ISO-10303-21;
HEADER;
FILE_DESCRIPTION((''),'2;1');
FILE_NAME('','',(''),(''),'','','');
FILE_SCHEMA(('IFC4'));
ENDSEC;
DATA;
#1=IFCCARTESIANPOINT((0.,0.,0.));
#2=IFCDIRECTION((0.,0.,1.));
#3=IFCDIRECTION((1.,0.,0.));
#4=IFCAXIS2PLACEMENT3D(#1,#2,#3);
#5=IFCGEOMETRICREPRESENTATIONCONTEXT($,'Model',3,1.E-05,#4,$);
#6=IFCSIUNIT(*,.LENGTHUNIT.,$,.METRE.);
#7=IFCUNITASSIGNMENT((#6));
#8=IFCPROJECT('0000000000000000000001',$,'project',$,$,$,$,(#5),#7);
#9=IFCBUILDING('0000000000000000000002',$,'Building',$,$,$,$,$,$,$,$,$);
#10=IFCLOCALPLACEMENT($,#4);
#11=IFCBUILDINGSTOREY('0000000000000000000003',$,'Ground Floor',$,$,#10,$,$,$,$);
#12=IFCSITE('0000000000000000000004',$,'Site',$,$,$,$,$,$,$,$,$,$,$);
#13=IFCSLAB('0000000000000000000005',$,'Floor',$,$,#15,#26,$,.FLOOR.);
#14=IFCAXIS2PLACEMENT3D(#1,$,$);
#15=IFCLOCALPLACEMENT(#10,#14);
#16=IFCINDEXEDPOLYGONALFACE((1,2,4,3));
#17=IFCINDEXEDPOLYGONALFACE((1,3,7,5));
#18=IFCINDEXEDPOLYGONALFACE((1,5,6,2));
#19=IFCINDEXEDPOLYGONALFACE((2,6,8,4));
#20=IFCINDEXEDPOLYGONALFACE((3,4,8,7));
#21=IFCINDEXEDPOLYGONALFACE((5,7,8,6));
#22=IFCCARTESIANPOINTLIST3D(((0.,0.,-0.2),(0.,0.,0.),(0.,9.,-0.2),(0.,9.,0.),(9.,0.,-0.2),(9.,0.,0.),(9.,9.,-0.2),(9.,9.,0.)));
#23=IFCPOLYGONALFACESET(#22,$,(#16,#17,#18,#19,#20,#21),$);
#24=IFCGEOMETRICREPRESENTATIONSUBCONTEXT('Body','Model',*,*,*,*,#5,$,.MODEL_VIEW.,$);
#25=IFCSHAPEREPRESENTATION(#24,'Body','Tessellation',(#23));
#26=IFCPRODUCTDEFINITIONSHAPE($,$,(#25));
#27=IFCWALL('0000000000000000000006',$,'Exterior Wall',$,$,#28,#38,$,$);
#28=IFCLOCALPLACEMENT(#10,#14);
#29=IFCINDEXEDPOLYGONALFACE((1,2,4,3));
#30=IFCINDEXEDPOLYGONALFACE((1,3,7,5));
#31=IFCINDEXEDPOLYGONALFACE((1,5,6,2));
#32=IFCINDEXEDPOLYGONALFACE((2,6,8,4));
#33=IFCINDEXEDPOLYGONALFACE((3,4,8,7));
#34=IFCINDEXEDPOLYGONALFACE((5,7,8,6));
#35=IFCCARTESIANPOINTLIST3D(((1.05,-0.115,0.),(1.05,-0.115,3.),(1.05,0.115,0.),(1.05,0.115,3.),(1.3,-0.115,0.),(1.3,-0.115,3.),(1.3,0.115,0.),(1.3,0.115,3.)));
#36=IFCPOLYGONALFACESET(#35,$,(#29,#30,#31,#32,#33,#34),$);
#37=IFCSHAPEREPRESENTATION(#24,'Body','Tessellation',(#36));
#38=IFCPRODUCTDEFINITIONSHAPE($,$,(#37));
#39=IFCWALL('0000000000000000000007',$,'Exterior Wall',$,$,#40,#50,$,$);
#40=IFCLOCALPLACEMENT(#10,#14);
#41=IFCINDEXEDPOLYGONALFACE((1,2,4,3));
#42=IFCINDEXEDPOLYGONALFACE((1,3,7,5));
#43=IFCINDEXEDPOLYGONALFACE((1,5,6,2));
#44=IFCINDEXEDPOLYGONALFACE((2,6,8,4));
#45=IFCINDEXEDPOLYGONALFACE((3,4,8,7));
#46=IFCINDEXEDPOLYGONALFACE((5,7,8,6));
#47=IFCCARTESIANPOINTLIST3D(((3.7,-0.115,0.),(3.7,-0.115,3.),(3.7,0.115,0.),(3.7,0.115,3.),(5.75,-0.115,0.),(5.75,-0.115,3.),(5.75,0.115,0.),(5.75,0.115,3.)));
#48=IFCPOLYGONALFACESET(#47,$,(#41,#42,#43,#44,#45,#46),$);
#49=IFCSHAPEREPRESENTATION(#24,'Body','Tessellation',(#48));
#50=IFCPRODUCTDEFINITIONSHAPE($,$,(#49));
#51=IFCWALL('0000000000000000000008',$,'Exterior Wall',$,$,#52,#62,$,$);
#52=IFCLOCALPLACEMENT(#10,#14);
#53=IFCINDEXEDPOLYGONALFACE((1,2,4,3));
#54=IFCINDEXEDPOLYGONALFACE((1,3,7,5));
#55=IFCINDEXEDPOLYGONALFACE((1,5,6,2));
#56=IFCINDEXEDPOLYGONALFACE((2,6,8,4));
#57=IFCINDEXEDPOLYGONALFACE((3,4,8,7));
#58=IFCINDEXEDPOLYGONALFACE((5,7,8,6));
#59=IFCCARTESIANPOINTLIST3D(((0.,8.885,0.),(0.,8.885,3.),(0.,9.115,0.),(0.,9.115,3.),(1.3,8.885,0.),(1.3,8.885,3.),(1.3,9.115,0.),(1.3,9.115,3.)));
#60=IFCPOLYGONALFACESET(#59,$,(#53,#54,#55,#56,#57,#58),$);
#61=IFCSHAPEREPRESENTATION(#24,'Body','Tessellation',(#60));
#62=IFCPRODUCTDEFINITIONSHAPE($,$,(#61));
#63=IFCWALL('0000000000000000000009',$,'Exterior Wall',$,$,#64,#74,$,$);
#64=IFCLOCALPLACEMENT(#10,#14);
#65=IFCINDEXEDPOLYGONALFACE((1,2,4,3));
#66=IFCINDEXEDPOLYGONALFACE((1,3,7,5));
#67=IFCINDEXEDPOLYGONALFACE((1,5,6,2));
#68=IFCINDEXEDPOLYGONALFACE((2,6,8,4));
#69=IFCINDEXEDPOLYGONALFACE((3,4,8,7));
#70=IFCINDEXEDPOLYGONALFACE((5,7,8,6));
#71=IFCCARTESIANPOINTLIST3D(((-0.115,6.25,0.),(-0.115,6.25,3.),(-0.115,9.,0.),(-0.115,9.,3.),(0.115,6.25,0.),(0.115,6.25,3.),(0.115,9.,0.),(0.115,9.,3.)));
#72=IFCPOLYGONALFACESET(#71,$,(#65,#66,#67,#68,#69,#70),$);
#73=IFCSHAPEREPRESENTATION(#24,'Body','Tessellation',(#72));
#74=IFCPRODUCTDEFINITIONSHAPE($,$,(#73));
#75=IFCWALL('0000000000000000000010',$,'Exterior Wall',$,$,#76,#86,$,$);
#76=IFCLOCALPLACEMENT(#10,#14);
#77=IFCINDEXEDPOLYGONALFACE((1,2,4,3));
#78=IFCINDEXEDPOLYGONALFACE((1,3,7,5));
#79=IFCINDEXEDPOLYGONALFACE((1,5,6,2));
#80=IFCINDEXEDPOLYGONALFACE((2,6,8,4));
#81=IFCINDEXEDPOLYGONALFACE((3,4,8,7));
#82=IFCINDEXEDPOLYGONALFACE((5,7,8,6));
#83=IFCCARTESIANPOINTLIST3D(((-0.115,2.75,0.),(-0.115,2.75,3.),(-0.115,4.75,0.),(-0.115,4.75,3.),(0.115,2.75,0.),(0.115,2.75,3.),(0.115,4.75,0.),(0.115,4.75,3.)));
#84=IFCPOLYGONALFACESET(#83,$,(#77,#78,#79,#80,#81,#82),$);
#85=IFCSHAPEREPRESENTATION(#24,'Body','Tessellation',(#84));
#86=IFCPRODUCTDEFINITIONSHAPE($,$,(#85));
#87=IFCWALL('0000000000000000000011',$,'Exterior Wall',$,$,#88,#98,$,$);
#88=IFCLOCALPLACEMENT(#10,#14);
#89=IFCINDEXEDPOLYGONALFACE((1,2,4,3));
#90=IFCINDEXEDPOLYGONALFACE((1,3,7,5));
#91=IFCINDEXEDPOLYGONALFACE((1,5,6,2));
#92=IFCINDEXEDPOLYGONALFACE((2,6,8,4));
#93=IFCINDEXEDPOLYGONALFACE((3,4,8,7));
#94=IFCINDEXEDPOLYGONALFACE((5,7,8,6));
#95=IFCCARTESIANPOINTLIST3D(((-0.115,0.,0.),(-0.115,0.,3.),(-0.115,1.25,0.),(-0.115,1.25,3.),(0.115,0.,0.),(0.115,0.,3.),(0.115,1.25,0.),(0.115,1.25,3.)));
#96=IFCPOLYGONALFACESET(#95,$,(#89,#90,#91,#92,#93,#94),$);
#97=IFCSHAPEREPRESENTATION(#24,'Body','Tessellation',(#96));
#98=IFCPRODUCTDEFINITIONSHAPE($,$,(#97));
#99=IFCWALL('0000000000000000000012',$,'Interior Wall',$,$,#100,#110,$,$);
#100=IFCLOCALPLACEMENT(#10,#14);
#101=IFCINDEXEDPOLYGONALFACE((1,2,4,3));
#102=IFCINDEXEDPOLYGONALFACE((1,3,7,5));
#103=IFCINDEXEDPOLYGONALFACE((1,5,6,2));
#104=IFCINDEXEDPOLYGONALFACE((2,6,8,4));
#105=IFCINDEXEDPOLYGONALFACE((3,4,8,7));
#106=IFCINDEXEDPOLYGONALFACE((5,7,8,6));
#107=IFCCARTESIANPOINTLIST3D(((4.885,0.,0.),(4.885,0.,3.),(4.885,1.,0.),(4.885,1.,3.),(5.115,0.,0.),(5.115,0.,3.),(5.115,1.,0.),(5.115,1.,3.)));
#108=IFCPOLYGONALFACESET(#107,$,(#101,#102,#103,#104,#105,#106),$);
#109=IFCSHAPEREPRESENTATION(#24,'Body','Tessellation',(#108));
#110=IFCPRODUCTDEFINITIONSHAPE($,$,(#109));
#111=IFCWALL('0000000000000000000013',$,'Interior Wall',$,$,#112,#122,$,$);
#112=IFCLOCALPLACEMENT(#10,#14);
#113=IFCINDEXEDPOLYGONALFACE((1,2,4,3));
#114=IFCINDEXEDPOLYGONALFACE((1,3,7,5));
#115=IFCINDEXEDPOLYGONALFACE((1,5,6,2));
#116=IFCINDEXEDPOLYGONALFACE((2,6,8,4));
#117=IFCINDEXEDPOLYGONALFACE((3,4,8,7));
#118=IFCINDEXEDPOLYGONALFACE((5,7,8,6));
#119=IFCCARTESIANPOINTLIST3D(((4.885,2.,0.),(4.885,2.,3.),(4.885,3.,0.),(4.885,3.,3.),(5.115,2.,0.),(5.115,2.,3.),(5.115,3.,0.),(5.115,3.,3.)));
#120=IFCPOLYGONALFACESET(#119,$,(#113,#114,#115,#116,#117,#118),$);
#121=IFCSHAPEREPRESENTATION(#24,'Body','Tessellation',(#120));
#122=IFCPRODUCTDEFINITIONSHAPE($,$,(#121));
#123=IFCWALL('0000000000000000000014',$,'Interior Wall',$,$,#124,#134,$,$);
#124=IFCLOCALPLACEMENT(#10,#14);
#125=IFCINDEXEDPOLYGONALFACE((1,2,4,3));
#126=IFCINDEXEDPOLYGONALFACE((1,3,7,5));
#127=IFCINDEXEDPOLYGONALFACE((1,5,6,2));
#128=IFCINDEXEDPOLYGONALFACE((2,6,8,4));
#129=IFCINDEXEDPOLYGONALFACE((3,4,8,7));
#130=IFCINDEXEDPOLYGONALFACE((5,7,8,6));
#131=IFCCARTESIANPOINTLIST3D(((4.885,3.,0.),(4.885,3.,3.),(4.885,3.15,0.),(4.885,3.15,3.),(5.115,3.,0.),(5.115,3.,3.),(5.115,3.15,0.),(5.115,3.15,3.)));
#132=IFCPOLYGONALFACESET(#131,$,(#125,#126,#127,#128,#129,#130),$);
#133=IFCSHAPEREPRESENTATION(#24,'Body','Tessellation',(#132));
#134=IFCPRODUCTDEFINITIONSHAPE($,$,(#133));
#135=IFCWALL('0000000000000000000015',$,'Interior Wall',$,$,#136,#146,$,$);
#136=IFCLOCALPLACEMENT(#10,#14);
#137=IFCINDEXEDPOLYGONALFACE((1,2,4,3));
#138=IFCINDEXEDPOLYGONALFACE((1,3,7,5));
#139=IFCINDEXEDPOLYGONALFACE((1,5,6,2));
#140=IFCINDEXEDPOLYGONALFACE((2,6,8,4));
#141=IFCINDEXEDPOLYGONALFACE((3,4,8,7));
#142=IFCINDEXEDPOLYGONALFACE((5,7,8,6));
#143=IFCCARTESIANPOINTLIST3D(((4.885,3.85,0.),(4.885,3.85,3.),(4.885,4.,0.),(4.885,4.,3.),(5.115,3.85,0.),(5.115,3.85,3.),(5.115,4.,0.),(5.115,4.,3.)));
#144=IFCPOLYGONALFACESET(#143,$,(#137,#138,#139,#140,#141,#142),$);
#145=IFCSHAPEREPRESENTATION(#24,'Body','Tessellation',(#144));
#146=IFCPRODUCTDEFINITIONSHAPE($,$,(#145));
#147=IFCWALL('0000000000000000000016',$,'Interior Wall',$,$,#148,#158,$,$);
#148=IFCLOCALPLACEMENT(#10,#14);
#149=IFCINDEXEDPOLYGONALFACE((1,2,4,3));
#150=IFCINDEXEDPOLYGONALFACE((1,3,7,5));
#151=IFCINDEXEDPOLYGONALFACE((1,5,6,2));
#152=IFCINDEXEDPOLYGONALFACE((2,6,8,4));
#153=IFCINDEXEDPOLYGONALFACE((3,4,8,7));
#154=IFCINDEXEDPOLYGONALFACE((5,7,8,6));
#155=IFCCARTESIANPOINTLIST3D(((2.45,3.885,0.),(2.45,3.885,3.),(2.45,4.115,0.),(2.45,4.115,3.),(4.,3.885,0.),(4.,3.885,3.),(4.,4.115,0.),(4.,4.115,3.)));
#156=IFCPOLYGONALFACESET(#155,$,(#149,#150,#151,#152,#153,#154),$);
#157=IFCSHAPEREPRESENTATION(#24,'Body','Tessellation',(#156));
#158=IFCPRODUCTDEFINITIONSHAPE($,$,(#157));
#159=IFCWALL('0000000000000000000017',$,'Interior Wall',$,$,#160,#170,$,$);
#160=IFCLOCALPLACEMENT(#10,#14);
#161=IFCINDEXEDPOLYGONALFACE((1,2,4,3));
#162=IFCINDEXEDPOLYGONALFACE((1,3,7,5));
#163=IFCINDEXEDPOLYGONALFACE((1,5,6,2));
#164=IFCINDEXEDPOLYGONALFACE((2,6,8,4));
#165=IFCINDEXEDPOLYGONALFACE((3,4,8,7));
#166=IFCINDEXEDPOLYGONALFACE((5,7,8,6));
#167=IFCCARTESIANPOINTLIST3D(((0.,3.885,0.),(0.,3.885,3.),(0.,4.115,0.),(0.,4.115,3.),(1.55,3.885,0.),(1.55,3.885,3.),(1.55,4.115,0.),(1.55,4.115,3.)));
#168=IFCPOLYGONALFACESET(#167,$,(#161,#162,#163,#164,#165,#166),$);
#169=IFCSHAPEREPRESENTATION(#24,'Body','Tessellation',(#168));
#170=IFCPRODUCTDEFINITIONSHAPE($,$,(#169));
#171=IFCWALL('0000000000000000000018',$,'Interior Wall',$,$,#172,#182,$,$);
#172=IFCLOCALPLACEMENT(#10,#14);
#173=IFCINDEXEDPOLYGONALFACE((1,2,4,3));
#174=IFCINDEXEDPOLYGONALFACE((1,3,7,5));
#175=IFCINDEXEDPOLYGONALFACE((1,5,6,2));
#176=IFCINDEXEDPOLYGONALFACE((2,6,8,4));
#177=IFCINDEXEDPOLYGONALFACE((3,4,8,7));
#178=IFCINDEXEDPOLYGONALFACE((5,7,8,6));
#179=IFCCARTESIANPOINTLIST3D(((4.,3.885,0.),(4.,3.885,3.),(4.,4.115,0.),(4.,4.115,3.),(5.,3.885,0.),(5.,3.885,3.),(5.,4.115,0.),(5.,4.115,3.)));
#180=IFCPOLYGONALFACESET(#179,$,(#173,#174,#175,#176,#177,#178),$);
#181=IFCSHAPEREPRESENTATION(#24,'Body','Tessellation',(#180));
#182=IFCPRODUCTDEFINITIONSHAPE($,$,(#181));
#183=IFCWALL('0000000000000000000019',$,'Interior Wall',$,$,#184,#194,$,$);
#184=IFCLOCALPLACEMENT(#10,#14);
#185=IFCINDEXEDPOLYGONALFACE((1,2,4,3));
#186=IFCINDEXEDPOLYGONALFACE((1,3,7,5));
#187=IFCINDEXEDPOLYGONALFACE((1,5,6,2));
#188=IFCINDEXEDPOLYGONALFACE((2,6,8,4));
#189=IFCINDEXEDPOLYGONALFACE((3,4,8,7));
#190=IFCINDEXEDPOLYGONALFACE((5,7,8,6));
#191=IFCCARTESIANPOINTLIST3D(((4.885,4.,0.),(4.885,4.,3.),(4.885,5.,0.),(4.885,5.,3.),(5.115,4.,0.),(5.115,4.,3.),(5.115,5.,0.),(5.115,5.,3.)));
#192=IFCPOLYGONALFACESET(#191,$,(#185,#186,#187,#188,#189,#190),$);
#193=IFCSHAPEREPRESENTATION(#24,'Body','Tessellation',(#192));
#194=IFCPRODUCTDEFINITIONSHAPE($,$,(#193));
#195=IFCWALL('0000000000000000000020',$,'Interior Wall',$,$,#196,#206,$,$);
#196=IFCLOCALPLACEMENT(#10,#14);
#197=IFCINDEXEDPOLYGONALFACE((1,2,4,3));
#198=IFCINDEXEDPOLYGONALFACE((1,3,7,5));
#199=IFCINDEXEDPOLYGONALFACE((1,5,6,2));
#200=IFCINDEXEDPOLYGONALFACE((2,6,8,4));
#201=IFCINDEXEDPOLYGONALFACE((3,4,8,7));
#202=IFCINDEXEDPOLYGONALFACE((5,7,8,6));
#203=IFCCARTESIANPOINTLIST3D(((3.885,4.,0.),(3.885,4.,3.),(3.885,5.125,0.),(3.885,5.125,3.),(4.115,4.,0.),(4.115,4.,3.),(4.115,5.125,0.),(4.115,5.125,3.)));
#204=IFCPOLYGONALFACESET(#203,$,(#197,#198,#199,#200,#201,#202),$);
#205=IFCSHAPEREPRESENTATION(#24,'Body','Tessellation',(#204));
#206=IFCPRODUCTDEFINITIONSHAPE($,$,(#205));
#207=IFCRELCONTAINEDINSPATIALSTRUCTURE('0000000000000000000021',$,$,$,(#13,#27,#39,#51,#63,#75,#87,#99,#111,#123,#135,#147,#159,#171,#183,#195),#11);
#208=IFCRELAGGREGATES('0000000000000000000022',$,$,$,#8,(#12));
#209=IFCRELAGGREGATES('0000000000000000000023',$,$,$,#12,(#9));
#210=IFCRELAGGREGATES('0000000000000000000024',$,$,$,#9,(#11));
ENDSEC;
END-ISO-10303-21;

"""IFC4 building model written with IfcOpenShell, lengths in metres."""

from ifc_helpers import new_model, si_unit, frame, origin_with_axes, place, context, subcontext, project, spatial, indexed_curve, outline, extrude, element, save


model = new_model("IFC4")

# Units and contexts
model_context = context("Model", 3, precision=1e-05, world=origin_with_axes())
body_context = subcontext(model_context, "Body", "Model", "MODEL_VIEW")
ifc_project = project(units=[si_unit("LENGTHUNIT", "METRE")], contexts=[model_context])

# Site, building, storey
site = spatial("IfcSite", under=ifc_project, Name="Site")
building = spatial("IfcBuilding", under=site, Name="Building")
storey_placement = place(None, origin_with_axes())
storey = spatial("IfcBuildingStorey", under=building, at=storey_placement, Name="Ground Floor")

# Slab
slab_placement = place(storey_placement, frame((0.0, 0.0, -0.2), z_axis=(0.0, 0.0, 1.0), x_axis=(1.0, 0.0, 0.0)))
element("IfcSlab", 1, at=slab_placement, inside=storey, Name="Floor", PredefinedType="FLOOR", context=body_context, shape_type="SweptSolid", body=[
    extrude(outline(indexed_curve([(0.0, 0.0), (9.0, 0.0), (9.0, 9.0), (0.0, 9.0)])), None, (0.0, 0.0, 1.0), 0.2),
])

# Walls
wall_1_placement = place(storey_placement, frame((1.05, 0.0, 0.0), z_axis=(0.0, 0.0, 1.0), x_axis=(1.0, 0.0, 0.0)))
element("IfcWall", 2, at=wall_1_placement, inside=storey, Name="Exterior Wall", context=body_context, shape_type="SweptSolid", body=[
    extrude(outline(indexed_curve([(0.0, 0.0), (0.0, 0.23), (0.25, 0.23), (0.25, 0.0), (0.0, 0.0)], self_intersect=False)), frame((0.0, -0.115, 0.0), z_axis=(0.0, 0.0, 1.0), x_axis=(1.0, 0.0, 0.0)), (0.0, 0.0, 1.0), 3.0),
])
wall_2_placement = place(storey_placement, frame((3.7, 0.0, 0.0), z_axis=(0.0, 0.0, 1.0), x_axis=(1.0, 0.0, 0.0)))
element("IfcWall", 3, at=wall_2_placement, inside=storey, Name="Exterior Wall", context=body_context, shape_type="SweptSolid", body=[
    extrude(outline(indexed_curve([(0.0, 0.0), (0.0, 0.23), (2.05, 0.23), (2.05, 0.0), (0.0, 0.0)], self_intersect=False)), frame((0.0, -0.115, 0.0), z_axis=(0.0, 0.0, 1.0), x_axis=(1.0, 0.0, 0.0)), (0.0, 0.0, 1.0), 3.0),
])
wall_3_placement = place(storey_placement, frame((1.3, 9.0, 0.0), z_axis=(0.0, 0.0, 1.0), x_axis=(-1.0, 0.0, 0.0)))
element("IfcWall", 4, at=wall_3_placement, inside=storey, Name="Exterior Wall", context=body_context, shape_type="SweptSolid", body=[
    extrude(outline(indexed_curve([(0.0, 0.0), (0.0, 0.23), (1.3, 0.23), (1.3, 0.0), (0.0, 0.0)], self_intersect=False)), frame((0.0, -0.115, 0.0), z_axis=(0.0, 0.0, 1.0), x_axis=(1.0, 0.0, 0.0)), (0.0, 0.0, 1.0), 3.0),
])
wall_4_placement = place(storey_placement, frame((0.0, 9.0, 0.0), z_axis=(0.0, 0.0, 1.0), x_axis=(0.0, -1.0, 0.0)))
element("IfcWall", 5, at=wall_4_placement, inside=storey, Name="Exterior Wall", context=body_context, shape_type="SweptSolid", body=[
    extrude(outline(indexed_curve([(0.0, 0.0), (0.0, 0.23), (2.75, 0.23), (2.75, 0.0), (0.0, 0.0)], self_intersect=False)), frame((0.0, -0.115, 0.0), z_axis=(0.0, 0.0, 1.0), x_axis=(1.0, 0.0, 0.0)), (0.0, 0.0, 1.0), 3.0),
])
wall_5_placement = place(storey_placement, frame((0.0, 4.75, 0.0), z_axis=(0.0, 0.0, 1.0), x_axis=(0.0, -1.0, 0.0)))
element("IfcWall", 6, at=wall_5_placement, inside=storey, Name="Exterior Wall", context=body_context, shape_type="SweptSolid", body=[
    extrude(outline(indexed_curve([(0.0, 0.0), (0.0, 0.23), (2.0, 0.23), (2.0, 0.0), (0.0, 0.0)], self_intersect=False)), frame((0.0, -0.115, 0.0), z_axis=(0.0, 0.0, 1.0), x_axis=(1.0, 0.0, 0.0)), (0.0, 0.0, 1.0), 3.0),
])
wall_6_placement = place(storey_placement, frame((0.0, 1.25, 0.0), z_axis=(0.0, 0.0, 1.0), x_axis=(0.0, -1.0, 0.0)))
element("IfcWall", 7, at=wall_6_placement, inside=storey, Name="Exterior Wall", context=body_context, shape_type="SweptSolid", body=[
    extrude(outline(indexed_curve([(0.0, 0.0), (0.0, 0.23), (1.25, 0.23), (1.25, 0.0), (0.0, 0.0)], self_intersect=False)), frame((0.0, -0.115, 0.0), z_axis=(0.0, 0.0, 1.0), x_axis=(1.0, 0.0, 0.0)), (0.0, 0.0, 1.0), 3.0),
])
for number, where, z_axis, x_axis, name in (
    (8, (5.0, 0.0, 0.0), (0.0, 0.0, 1.0), (0.0, 1.0, 0.0), "Interior Wall"),
    (9, (5.0, 2.0, 0.0), (0.0, 0.0, 1.0), (0.0, 1.0, 0.0), "Interior Wall"),
):
    element("IfcWall", number, at=place(storey_placement, frame(where, z_axis=z_axis, x_axis=x_axis)), inside=storey, Name=name, context=body_context, shape_type="SweptSolid", body=[
        extrude(outline(indexed_curve([(0.0, 0.0), (0.0, 0.23), (1.0, 0.23), (1.0, 0.0), (0.0, 0.0)], self_intersect=False)), frame((0.0, -0.115, 0.0), z_axis=(0.0, 0.0, 1.0), x_axis=(1.0, 0.0, 0.0)), (0.0, 0.0, 1.0), 3.0),
    ])
for number, where, z_axis, x_axis, name in (
    (10, (5.0, 3.0, 0.0), (0.0, 0.0, 1.0), (0.0, 1.0, 0.0), "Interior Wall"),
    (11, (5.0, 3.85, 0.0), (0.0, 0.0, 1.0), (0.0, 1.0, 0.0), "Interior Wall"),
):
    element("IfcWall", number, at=place(storey_placement, frame(where, z_axis=z_axis, x_axis=x_axis)), inside=storey, Name=name, context=body_context, shape_type="SweptSolid", body=[
        extrude(outline(indexed_curve([(0.0, 0.0), (0.0, 0.23), (0.15, 0.23), (0.15, 0.0), (0.0, 0.0)], self_intersect=False)), frame((0.0, -0.115, 0.0), z_axis=(0.0, 0.0, 1.0), x_axis=(1.0, 0.0, 0.0)), (0.0, 0.0, 1.0), 3.0),
    ])
for number, where, z_axis, x_axis, name in (
    (12, (4.0, 4.0, 0.0), (0.0, 0.0, 1.0), (-1.0, 0.0, 0.0), "Interior Wall"),
    (13, (1.55, 4.0, 0.0), (0.0, 0.0, 1.0), (-1.0, 0.0, 0.0), "Interior Wall"),
):
    element("IfcWall", number, at=place(storey_placement, frame(where, z_axis=z_axis, x_axis=x_axis)), inside=storey, Name=name, context=body_context, shape_type="SweptSolid", body=[
        extrude(outline(indexed_curve([(0.0, 0.0), (0.0, 0.23), (1.55, 0.23), (1.55, 0.0), (0.0, 0.0)], self_intersect=False)), frame((0.0, -0.115, 0.0), z_axis=(0.0, 0.0, 1.0), x_axis=(1.0, 0.0, 0.0)), (0.0, 0.0, 1.0), 3.0),
    ])
for number, where, z_axis, x_axis, name in (
    (14, (5.0, 4.0, 0.0), (0.0, 0.0, 1.0), (-1.0, 0.0, 0.0), "Interior Wall"),
    (15, (5.0, 5.0, 0.0), (0.0, 0.0, 1.0), (0.0, -1.0, 0.0), "Interior Wall"),
):
    element("IfcWall", number, at=place(storey_placement, frame(where, z_axis=z_axis, x_axis=x_axis)), inside=storey, Name=name, context=body_context, shape_type="SweptSolid", body=[
        extrude(outline(indexed_curve([(0.0, 0.0), (0.0, 0.23), (1.0, 0.23), (1.0, 0.0), (0.0, 0.0)], self_intersect=False)), frame((0.0, -0.115, 0.0), z_axis=(0.0, 0.0, 1.0), x_axis=(1.0, 0.0, 0.0)), (0.0, 0.0, 1.0), 3.0),
    ])
for number, where, z_axis, x_axis, name in (
    (16, (4.0, 4.0, 0.0), (0.0, 0.0, 1.0), (0.0, 1.0, 0.0), "Interior Wall"),
):
    element("IfcWall", number, at=place(storey_placement, frame(where, z_axis=z_axis, x_axis=x_axis)), inside=storey, Name=name, context=body_context, shape_type="SweptSolid", body=[
        extrude(outline(indexed_curve([(0.0, 0.0), (0.0, 0.23), (1.125, 0.23), (1.125, 0.0), (0.0, 0.0)], self_intersect=False)), frame((0.0, -0.115, 0.0), z_axis=(0.0, 0.0, 1.0), x_axis=(1.0, 0.0, 0.0)), (0.0, 0.0, 1.0), 3.0),
    ])

save(model, "model.ifc")
